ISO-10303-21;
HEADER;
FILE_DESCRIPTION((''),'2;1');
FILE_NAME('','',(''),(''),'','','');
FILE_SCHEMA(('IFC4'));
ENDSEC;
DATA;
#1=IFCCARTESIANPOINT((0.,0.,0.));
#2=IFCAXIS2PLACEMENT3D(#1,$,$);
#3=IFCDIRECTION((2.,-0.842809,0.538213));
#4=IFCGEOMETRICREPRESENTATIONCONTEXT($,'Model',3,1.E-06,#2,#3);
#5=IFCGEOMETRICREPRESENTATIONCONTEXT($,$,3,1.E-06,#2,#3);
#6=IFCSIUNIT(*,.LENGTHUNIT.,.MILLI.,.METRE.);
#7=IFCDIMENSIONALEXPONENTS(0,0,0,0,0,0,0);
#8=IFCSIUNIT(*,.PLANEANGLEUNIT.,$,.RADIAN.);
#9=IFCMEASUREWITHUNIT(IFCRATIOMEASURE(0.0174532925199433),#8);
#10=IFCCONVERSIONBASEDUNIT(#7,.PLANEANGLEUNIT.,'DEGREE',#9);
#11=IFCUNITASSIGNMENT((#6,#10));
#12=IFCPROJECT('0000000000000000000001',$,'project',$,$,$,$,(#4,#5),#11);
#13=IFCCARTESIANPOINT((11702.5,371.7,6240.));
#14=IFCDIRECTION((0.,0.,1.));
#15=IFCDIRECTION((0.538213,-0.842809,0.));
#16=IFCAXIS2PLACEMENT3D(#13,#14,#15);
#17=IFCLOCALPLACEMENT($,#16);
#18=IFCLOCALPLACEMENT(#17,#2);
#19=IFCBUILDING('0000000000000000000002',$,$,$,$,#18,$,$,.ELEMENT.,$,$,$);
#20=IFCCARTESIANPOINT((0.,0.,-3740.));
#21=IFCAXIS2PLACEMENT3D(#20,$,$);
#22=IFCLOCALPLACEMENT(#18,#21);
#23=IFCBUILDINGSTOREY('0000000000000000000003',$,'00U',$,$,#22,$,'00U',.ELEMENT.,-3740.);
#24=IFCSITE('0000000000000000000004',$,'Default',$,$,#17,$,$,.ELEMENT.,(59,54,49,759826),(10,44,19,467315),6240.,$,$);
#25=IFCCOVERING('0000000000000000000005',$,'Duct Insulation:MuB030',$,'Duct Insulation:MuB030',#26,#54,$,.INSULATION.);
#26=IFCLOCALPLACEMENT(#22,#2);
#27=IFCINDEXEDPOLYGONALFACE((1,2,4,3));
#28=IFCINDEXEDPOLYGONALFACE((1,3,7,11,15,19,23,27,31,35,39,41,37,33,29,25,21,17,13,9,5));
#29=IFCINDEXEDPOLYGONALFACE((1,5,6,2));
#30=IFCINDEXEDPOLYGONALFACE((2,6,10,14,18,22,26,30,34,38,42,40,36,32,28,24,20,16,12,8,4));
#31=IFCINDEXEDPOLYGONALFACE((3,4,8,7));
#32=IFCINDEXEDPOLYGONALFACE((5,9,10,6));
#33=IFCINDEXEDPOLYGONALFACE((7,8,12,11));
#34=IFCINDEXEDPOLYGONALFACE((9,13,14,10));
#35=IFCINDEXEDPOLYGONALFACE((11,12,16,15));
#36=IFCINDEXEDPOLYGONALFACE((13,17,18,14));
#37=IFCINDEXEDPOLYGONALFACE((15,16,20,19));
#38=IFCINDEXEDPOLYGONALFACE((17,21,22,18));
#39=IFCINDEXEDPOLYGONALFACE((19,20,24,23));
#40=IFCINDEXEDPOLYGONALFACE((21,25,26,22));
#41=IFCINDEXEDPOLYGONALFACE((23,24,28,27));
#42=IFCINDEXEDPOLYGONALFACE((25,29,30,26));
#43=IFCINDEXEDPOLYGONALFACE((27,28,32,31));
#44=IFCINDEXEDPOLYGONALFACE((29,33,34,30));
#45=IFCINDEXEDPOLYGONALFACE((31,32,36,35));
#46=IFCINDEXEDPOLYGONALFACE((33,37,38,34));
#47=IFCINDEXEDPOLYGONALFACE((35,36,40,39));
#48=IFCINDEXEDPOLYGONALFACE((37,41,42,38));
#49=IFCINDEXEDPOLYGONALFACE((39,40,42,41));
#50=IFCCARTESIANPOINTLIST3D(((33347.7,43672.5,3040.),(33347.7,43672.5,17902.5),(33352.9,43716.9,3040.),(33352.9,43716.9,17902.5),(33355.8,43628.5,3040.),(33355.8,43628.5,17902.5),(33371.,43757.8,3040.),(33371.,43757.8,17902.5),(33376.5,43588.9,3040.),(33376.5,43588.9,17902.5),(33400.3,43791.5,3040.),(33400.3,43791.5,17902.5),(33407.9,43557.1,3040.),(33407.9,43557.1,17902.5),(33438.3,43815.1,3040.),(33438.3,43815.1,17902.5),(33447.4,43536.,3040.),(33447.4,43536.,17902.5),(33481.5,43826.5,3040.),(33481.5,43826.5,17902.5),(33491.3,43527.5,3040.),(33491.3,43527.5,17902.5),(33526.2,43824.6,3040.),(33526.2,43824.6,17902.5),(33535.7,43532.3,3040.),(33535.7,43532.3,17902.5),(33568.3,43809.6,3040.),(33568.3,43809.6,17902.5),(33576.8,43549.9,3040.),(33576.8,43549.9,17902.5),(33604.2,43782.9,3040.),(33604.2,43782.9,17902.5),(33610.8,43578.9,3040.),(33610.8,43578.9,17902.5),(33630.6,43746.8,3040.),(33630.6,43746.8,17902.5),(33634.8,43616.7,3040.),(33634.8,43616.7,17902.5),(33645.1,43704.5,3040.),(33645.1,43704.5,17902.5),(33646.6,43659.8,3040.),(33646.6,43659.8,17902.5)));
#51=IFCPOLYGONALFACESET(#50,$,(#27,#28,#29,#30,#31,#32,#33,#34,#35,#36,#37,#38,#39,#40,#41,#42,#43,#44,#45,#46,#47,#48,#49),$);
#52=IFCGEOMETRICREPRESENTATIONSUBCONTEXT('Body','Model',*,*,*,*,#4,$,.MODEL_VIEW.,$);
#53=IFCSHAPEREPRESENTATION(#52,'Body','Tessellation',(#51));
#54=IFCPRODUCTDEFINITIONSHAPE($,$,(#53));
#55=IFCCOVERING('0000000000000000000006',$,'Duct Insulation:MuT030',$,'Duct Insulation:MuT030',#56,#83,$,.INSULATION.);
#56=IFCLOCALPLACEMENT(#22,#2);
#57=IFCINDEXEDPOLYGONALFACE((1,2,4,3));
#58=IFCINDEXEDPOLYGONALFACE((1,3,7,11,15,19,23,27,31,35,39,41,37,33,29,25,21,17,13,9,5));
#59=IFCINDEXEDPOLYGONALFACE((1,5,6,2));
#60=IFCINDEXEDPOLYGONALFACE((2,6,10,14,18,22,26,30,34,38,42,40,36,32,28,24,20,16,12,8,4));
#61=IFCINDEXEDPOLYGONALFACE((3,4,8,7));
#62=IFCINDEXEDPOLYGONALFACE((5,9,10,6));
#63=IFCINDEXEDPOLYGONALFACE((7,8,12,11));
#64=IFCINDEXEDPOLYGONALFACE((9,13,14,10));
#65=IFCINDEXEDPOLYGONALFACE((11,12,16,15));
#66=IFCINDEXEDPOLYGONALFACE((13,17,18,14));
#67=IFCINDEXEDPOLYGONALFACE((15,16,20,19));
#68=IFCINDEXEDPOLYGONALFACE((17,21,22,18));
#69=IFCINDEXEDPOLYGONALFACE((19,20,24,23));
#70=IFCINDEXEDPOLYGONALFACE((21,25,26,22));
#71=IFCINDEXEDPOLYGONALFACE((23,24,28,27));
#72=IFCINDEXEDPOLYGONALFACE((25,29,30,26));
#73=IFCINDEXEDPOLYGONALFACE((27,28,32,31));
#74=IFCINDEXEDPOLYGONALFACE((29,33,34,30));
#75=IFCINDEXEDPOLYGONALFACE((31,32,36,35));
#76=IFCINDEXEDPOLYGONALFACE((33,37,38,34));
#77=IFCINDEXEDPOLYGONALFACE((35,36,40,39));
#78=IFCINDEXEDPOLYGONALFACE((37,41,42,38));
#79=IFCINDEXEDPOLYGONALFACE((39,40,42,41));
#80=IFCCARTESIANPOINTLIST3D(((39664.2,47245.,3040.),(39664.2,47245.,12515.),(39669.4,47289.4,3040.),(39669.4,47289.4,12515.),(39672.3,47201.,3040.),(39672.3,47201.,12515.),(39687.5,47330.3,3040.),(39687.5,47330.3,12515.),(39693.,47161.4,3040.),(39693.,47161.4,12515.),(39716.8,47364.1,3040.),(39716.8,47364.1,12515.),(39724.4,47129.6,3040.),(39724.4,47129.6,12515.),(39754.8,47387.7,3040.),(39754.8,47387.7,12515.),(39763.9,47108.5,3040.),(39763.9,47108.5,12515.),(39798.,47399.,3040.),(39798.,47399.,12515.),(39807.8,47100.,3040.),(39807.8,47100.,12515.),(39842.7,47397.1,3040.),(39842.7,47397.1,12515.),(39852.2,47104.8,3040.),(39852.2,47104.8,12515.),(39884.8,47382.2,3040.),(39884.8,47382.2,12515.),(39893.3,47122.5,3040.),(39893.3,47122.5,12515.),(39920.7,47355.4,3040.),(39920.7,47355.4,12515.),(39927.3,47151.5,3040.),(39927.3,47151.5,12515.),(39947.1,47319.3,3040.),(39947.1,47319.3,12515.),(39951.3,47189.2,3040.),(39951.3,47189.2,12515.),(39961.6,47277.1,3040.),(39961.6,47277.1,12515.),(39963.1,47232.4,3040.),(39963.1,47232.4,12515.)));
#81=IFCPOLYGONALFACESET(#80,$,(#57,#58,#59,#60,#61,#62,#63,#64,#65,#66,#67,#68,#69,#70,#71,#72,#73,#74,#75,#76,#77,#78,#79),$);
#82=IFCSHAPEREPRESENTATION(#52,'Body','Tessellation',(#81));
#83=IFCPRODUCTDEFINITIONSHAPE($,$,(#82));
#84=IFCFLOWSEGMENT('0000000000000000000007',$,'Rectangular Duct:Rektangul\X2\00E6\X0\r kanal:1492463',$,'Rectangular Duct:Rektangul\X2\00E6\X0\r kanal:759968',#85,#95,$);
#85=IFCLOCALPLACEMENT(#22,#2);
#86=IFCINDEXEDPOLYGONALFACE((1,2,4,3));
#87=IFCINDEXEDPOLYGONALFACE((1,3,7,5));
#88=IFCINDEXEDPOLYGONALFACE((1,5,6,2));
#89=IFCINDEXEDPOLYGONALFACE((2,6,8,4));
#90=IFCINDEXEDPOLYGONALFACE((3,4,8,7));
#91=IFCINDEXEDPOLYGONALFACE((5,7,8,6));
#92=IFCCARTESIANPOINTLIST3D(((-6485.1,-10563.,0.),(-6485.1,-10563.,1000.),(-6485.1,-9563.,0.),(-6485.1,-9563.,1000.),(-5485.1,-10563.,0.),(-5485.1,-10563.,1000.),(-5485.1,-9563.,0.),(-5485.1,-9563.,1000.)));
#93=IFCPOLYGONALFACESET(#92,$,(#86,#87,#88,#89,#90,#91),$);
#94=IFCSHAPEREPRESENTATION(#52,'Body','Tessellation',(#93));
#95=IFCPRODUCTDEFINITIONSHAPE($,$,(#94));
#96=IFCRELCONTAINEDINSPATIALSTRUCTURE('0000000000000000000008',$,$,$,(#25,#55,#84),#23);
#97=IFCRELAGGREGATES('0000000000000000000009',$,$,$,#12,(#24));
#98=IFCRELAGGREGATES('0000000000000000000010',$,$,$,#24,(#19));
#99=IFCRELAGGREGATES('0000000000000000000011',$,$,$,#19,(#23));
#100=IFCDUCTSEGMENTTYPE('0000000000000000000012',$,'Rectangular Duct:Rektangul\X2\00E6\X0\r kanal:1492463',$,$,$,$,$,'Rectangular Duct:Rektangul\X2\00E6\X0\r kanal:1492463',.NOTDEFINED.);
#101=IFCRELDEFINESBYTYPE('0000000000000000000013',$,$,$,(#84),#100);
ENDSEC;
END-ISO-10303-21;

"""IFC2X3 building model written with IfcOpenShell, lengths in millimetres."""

from ifc_helpers import new_model, entity, si_unit, converted_unit, direction, frame, frame_2d, origin, place, context, subcontext, project, spatial, rectangle, circle, extrude, type_object, element, save


model = new_model("IFC2X3")

# Units and contexts
model_context = context("Model", 3, precision=1e-06, world=origin(), true_north=direction((2.0, -0.842809, 0.538213)))
context_of_model = context(None, 3, precision=1e-06, world=origin(), true_north=direction((2.0, -0.842809, 0.538213)))
body_context = subcontext(model_context, "Body", "Model", "MODEL_VIEW")
ifc_project = project(units=[si_unit("LENGTHUNIT", "METRE", prefix="MILLI"), converted_unit("PLANEANGLEUNIT", "DEGREE", entity("IfcRatioMeasure", 0.0174532925199433), si_unit("PLANEANGLEUNIT", "RADIAN"), dimensions=[0, 0, 0, 0, 0, 0, 0])], contexts=[model_context, context_of_model])

# Site, building, storey
site_placement = place(None, frame((11702.5, 371.7, 6240.0), z_axis=(0.0, 0.0, 1.0), x_axis=(0.538213, -0.842809, 0.0)))
site = spatial("IfcSite", under=ifc_project, at=site_placement, Name="Default", CompositionType="ELEMENT", RefLatitude=(59, 54, 49, 759826), RefLongitude=(10, 44, 19, 467315), RefElevation=6240.0)
building_placement = place(site_placement, origin())
building = spatial("IfcBuilding", under=site, at=building_placement, CompositionType="ELEMENT")
storey_placement = place(building_placement, frame((0.0, 0.0, -3740.0)))
storey = spatial("IfcBuildingStorey", under=building, at=storey_placement, Name="00U", LongName="00U", CompositionType="ELEMENT", Elevation=-3740.0)

# Coverings
covering_1_placement = place(storey_placement, origin())
element("IfcCovering", 1, at=covering_1_placement, inside=storey, Name="Duct Insulation:MuB030", ObjectType="Duct Insulation:MuB030", PredefinedType="INSULATION", context=body_context, shape_type="SweptSolid", body=[
    extrude(circle(Radius=150.0, at=frame_2d((0.0, 0.0), x_axis=(1.0, 0.0))), frame((33497.6, 43677.3, 3040.0), z_axis=(0.0, 0.0, 1.0), x_axis=(0.710554, 0.703643, 0.0)), (0.0, 0.0, 1.0), 14862.5),
])
covering_2_placement = place(storey_placement, origin())
element("IfcCovering", 2, at=covering_2_placement, inside=storey, Name="Duct Insulation:MuT030", ObjectType="Duct Insulation:MuT030", PredefinedType="INSULATION", context=body_context, shape_type="SweptSolid", body=[
    extrude(circle(Radius=150.0, at=frame_2d((0.0, 0.0), x_axis=(1.0, 0.0))), frame((39814.1, 47249.9, 3040.0), z_axis=(0.0, 0.0, 1.0), x_axis=(0.710554, 0.703643, 0.0)), (0.0, 0.0, 1.0), 9475.0),
])

# Flow segment
duct_segment_type = type_object("IfcDuctSegmentType", Name="Rectangular Duct:Rektangulær kanal:1492463", ElementType="Rectangular Duct:Rektangulær kanal:1492463", PredefinedType="NOTDEFINED")
flow_segment_placement = place(storey_placement, origin())
element("IfcFlowSegment", 3, at=flow_segment_placement, inside=storey, type_object=duct_segment_type, Name="Rectangular Duct:Rektangulær kanal:1492463", ObjectType="Rectangular Duct:Rektangulær kanal:759968", context=body_context, shape_type="SweptSolid", body=[
    extrude(rectangle(XDim=1000.0, YDim=1000.0, at=frame_2d((0.0, 0.0), x_axis=(1.0, 0.0))), frame((-5985.1, -10063.0, 0.0), z_axis=(0.0, 0.0, 1.0), x_axis=(0.0, -1.0, 0.0)), (0.0, 0.0, 1.0), 1000.0),
])

save(model, "model.ifc")
